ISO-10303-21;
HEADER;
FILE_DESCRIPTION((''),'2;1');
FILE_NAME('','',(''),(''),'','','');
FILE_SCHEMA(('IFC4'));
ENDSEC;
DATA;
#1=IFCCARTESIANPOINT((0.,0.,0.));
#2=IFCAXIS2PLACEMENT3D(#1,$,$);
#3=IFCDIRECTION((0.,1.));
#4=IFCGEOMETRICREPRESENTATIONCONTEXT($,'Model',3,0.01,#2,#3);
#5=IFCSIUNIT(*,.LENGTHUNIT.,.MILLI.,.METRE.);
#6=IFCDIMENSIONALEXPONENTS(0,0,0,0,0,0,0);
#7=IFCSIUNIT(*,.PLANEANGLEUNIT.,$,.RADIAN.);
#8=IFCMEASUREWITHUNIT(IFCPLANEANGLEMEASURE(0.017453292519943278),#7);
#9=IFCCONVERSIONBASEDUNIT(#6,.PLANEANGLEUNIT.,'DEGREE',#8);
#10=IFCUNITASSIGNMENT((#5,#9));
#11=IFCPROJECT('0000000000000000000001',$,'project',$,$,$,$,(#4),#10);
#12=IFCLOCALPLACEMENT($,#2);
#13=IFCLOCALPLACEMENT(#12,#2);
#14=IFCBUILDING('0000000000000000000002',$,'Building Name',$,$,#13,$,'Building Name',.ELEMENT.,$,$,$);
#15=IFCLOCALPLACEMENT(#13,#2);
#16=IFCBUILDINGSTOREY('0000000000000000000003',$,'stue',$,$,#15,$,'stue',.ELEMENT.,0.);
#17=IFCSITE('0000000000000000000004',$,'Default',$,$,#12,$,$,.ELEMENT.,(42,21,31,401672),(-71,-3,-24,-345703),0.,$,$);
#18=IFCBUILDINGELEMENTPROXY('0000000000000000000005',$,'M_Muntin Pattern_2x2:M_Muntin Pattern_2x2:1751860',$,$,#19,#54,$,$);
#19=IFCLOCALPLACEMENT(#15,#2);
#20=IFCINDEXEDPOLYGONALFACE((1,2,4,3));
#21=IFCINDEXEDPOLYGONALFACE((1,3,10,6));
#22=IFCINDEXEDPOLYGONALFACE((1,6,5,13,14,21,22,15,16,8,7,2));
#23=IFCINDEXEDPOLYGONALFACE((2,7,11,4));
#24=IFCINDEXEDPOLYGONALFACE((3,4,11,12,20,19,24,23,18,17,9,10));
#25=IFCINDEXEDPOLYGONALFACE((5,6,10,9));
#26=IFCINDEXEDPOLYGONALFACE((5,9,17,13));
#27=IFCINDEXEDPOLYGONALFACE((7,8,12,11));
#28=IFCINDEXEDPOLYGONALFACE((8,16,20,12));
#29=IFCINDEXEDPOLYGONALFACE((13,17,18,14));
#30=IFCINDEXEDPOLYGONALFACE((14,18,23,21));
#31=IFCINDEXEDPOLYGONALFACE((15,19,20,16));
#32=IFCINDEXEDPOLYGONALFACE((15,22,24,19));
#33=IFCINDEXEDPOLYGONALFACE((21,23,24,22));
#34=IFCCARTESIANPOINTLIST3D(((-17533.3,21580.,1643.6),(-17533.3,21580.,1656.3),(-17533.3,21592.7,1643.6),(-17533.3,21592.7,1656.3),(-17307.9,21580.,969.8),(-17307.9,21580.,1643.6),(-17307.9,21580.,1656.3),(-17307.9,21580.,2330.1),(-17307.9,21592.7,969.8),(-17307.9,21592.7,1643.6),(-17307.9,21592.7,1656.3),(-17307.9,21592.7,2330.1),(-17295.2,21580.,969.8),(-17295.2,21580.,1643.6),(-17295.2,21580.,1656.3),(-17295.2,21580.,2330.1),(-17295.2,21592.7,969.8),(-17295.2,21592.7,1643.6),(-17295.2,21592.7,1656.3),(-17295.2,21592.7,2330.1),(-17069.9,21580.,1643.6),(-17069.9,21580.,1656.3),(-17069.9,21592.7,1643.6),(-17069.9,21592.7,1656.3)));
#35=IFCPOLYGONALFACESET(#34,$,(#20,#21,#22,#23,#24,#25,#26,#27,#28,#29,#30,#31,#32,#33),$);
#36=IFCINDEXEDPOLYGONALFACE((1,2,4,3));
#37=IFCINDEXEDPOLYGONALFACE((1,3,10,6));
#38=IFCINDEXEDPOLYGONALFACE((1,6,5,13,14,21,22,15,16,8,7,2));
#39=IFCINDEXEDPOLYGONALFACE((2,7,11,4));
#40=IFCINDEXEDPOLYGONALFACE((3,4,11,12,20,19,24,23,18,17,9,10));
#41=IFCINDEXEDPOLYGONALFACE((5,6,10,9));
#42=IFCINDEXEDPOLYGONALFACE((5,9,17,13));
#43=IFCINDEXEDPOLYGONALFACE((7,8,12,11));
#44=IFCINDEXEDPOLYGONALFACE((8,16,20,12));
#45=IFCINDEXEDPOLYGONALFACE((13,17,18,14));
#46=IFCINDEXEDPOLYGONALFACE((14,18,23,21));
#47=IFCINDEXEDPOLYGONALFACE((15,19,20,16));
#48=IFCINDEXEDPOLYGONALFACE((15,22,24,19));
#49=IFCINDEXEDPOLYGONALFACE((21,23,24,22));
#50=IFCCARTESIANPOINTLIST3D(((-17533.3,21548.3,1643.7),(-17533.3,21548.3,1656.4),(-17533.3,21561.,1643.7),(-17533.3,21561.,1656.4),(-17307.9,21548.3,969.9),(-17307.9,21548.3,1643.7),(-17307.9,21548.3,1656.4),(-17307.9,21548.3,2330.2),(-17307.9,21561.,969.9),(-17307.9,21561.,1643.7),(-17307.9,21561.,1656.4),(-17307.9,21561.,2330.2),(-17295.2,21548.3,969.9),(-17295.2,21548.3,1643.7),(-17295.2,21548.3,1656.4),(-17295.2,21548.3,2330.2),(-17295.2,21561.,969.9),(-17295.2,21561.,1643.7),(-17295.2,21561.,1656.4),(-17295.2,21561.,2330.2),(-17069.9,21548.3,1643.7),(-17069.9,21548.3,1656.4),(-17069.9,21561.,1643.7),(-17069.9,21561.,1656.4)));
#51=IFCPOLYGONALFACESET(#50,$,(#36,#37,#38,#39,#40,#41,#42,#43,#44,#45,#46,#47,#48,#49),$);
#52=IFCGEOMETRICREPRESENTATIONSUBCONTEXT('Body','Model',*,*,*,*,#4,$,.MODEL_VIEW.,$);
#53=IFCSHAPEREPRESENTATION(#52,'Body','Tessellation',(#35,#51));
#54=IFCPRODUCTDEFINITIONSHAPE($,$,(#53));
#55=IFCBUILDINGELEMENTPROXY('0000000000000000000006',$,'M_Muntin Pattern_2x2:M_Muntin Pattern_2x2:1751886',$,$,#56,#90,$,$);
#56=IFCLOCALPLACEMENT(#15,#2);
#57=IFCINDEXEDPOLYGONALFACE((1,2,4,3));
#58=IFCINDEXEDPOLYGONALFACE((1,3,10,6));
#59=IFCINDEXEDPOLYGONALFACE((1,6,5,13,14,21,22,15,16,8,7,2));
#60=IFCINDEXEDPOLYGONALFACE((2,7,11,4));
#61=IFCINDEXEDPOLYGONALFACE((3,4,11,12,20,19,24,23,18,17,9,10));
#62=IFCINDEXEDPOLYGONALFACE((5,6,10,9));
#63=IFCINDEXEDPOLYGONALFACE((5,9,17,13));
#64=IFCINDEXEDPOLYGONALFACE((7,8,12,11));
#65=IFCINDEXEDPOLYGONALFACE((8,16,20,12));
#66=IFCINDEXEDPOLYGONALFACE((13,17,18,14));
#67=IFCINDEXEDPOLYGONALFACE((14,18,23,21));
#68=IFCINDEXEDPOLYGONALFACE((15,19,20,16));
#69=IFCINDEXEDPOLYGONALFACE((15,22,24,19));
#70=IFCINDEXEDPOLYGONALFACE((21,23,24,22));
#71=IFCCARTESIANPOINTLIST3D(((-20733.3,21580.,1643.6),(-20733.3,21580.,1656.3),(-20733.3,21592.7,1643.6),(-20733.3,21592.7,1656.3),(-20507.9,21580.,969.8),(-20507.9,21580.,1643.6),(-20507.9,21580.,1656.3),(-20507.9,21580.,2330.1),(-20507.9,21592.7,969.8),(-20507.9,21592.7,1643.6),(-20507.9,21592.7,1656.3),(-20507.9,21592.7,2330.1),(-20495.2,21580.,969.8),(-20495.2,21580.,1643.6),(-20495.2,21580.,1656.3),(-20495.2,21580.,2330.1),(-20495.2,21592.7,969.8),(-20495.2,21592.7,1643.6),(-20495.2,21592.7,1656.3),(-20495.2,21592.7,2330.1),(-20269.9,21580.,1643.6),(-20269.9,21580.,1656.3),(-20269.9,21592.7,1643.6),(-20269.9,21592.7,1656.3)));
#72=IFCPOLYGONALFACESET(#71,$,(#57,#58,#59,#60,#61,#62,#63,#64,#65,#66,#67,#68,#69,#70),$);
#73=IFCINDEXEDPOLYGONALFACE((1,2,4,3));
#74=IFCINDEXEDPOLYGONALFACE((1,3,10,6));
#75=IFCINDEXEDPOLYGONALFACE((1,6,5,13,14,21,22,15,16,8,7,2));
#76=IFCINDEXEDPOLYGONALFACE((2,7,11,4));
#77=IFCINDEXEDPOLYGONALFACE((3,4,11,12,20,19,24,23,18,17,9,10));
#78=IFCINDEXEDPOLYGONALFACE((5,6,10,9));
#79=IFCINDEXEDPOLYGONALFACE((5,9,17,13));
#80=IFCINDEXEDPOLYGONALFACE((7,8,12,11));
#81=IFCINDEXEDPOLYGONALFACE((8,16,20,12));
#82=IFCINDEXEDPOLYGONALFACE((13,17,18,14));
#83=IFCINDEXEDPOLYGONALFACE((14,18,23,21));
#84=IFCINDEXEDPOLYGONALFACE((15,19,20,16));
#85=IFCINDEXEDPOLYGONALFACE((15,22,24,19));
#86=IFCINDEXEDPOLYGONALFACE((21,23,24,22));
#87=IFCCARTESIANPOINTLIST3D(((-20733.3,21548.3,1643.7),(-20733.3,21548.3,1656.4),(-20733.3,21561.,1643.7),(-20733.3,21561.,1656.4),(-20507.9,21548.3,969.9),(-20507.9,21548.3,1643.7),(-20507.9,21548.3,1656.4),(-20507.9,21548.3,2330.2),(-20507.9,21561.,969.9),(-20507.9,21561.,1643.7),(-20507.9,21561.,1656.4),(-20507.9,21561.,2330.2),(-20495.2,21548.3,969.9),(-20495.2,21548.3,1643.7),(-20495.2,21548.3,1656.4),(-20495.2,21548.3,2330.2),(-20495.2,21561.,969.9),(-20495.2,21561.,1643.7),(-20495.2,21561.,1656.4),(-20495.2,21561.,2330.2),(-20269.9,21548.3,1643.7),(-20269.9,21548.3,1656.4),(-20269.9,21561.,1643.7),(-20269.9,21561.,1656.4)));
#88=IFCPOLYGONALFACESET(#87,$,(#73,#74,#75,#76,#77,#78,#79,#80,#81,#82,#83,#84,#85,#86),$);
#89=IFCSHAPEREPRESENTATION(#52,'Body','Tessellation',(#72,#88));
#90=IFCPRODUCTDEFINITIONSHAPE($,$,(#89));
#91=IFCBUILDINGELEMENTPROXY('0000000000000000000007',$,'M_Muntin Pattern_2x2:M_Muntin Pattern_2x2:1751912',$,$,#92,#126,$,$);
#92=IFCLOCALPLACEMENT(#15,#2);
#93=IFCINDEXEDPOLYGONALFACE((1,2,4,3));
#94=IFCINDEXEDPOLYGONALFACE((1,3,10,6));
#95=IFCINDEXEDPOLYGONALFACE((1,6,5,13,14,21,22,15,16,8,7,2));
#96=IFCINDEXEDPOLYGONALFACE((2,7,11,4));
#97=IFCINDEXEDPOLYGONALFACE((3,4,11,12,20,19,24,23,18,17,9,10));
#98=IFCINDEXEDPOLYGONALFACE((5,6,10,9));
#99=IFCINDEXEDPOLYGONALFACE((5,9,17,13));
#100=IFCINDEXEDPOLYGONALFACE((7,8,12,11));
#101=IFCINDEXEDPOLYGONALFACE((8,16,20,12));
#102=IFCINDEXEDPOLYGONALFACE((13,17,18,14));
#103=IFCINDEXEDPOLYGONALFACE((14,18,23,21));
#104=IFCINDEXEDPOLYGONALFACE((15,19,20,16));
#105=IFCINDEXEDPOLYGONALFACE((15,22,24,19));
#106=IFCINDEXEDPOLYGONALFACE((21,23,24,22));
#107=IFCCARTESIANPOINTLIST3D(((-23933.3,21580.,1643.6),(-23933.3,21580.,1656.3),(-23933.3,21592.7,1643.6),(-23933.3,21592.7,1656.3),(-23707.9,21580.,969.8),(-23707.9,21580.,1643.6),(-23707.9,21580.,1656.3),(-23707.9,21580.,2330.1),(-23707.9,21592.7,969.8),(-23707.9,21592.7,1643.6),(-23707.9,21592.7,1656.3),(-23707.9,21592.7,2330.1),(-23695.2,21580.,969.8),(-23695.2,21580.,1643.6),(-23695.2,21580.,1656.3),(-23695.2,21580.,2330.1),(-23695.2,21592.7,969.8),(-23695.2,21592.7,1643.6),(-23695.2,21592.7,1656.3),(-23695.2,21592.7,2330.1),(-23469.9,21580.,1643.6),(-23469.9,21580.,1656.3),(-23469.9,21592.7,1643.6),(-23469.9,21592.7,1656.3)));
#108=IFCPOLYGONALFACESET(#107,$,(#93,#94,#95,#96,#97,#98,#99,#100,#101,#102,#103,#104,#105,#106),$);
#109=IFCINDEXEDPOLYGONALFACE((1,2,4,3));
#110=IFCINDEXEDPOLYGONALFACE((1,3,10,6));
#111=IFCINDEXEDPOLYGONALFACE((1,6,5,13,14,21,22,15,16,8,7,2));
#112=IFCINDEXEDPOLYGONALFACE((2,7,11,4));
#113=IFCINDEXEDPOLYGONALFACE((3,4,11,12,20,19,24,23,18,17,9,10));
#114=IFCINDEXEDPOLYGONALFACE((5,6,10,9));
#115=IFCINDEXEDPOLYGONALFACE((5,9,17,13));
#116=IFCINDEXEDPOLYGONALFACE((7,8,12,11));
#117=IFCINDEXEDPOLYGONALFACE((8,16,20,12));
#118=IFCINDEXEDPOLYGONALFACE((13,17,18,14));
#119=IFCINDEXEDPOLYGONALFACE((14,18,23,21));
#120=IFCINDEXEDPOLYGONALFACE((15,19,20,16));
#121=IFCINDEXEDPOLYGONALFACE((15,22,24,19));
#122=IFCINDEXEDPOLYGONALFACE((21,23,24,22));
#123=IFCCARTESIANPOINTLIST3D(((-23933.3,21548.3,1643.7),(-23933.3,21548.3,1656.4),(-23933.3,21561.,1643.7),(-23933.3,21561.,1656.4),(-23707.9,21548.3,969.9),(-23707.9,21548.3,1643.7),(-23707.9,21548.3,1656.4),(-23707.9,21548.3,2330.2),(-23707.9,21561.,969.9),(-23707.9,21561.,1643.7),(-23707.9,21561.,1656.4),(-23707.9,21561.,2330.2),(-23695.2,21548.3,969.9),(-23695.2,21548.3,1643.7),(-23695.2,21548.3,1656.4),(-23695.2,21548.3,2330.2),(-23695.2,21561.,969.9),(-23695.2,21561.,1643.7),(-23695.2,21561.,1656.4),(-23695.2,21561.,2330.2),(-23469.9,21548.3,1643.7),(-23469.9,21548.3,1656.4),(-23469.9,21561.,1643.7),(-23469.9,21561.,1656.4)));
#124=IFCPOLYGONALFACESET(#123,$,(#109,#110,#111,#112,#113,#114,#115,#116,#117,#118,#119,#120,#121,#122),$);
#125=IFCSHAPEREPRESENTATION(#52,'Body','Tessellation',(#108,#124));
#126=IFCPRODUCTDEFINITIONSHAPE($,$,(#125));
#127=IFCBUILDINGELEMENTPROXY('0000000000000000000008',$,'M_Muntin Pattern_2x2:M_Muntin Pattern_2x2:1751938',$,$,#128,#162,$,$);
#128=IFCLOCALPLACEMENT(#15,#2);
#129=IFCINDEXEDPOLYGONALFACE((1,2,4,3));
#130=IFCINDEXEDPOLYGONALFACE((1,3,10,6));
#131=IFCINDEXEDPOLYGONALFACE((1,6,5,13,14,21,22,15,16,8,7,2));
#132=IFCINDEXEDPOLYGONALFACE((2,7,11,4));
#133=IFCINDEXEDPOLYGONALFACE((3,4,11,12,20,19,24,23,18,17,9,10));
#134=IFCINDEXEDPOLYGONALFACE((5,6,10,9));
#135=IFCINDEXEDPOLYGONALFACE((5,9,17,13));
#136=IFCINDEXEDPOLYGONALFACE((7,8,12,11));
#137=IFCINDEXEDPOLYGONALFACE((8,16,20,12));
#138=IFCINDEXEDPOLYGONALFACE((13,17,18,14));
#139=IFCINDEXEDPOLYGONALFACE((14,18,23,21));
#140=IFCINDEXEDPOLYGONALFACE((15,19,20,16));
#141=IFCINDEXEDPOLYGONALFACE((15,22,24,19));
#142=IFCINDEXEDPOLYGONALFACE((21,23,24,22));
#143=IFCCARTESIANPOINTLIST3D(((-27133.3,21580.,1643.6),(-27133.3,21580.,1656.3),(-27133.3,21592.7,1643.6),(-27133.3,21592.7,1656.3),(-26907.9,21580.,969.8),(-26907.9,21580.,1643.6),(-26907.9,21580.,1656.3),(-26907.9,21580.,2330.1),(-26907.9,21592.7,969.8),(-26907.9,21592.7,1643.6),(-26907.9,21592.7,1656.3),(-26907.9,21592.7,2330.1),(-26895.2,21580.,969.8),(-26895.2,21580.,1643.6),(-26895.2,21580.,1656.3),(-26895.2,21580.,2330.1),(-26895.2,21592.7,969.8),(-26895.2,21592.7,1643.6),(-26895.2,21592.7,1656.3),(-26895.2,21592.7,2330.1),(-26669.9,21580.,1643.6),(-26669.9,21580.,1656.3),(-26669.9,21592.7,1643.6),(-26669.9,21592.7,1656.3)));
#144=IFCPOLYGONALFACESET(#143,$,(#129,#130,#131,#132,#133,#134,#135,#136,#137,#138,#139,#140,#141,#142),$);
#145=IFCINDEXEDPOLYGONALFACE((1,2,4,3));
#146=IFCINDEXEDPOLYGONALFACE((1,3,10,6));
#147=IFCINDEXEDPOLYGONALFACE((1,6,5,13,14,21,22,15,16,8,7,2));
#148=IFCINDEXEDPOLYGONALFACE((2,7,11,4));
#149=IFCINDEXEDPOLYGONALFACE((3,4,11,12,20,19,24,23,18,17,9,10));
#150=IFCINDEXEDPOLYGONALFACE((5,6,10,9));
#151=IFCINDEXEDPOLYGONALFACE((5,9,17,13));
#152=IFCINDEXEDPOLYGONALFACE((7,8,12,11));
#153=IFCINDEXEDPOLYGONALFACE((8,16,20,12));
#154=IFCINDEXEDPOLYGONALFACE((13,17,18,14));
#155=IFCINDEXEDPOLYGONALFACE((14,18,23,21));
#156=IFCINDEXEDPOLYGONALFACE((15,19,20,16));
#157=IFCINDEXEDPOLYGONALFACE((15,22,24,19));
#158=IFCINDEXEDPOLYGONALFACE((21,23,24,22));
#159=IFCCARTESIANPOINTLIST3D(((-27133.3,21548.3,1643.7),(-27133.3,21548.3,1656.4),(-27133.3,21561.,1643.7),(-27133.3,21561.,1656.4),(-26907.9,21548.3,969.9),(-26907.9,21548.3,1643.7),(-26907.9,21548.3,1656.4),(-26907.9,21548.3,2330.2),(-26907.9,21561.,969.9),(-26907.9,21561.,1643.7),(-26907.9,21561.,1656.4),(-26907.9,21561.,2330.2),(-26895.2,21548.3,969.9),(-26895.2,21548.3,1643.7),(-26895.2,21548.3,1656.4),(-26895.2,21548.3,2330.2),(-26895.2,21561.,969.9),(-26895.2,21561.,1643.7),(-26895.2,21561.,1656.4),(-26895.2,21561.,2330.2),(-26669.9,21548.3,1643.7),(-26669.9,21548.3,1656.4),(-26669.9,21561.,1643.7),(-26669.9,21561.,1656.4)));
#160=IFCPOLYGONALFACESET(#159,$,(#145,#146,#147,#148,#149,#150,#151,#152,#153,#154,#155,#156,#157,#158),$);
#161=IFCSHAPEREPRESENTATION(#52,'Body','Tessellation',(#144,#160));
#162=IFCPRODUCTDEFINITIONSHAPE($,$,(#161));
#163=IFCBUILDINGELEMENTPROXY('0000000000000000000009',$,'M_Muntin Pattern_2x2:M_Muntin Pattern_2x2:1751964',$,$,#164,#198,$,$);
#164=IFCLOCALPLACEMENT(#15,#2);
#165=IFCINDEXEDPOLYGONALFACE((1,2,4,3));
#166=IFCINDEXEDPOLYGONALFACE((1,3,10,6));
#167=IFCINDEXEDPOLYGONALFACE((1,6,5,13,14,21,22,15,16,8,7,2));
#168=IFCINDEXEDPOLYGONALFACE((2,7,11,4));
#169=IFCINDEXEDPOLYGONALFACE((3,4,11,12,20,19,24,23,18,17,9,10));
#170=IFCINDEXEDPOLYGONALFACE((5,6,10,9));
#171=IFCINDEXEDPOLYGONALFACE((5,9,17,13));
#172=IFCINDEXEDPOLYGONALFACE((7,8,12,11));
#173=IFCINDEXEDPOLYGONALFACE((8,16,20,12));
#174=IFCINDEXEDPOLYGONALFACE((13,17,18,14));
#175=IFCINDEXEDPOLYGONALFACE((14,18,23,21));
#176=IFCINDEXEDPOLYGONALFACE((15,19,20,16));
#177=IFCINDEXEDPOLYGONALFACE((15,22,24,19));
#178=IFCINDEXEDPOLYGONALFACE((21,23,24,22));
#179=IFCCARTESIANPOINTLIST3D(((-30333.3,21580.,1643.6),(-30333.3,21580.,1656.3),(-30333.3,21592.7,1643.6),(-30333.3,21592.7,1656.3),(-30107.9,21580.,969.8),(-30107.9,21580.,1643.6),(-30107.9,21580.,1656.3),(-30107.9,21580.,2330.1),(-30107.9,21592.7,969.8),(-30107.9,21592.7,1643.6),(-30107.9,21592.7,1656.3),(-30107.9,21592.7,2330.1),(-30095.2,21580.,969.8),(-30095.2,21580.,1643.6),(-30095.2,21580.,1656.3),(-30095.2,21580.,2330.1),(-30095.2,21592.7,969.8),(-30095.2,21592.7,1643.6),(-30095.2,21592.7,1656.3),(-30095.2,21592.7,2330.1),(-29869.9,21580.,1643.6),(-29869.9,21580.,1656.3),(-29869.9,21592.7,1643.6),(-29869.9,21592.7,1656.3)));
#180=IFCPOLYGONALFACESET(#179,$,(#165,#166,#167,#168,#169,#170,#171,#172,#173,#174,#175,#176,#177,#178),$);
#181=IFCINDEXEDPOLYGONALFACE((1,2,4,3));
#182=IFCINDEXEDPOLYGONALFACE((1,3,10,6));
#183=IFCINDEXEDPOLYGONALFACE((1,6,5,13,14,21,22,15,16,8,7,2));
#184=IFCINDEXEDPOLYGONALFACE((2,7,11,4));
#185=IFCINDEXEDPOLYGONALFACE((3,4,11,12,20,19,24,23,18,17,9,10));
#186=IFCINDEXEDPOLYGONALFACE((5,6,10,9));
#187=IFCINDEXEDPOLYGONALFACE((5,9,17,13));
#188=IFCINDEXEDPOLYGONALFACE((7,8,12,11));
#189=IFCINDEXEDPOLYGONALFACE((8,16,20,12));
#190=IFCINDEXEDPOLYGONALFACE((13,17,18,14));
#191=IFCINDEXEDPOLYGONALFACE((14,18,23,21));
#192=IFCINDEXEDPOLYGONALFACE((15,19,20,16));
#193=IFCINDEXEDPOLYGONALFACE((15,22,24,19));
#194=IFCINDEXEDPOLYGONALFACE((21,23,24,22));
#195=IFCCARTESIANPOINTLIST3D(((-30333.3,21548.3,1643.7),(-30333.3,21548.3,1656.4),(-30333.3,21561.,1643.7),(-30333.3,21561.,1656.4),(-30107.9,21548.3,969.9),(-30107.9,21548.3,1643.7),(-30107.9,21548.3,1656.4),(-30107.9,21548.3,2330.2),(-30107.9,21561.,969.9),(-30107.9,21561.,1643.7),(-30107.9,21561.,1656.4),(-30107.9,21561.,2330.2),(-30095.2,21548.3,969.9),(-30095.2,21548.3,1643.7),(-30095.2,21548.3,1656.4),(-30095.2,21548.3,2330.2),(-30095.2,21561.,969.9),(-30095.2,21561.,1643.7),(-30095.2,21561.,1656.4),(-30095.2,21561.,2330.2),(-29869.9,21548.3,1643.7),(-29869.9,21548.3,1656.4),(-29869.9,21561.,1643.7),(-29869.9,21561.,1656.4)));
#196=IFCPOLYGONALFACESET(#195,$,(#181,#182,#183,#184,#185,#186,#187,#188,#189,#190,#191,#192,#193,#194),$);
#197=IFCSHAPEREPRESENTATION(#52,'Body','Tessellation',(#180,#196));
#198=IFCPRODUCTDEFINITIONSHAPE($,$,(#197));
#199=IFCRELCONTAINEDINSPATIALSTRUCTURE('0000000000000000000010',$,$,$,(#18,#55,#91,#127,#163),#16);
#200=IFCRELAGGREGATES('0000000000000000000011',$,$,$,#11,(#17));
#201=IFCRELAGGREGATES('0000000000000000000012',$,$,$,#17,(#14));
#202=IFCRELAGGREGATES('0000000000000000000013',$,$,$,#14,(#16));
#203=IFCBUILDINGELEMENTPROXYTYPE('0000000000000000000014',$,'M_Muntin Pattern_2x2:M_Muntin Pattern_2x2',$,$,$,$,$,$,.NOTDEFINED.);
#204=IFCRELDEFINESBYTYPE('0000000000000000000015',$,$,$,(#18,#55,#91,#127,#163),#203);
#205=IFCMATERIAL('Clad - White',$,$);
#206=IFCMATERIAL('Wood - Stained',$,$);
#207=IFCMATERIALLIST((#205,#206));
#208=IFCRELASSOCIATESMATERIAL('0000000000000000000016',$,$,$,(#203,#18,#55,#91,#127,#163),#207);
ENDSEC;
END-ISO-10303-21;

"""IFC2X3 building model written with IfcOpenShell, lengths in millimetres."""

from ifc_helpers import new_model, entity, si_unit, converted_unit, direction, frame, origin, place, context, subcontext, project, spatial, polyline, outline, extrude, source, transform, mapped, material, material_list, type_object, type_shapes, element, save


model = new_model("IFC2X3")

# Units and contexts
model_context = context("Model", 3, precision=0.01, world=origin(), true_north=direction((0.0, 1.0)))
body_context = subcontext(model_context, "Body", "Model", "MODEL_VIEW")
ifc_project = project(units=[si_unit("LENGTHUNIT", "METRE", prefix="MILLI"), converted_unit("PLANEANGLEUNIT", "DEGREE", entity("IfcPlaneAngleMeasure", 0.017453292519943278), si_unit("PLANEANGLEUNIT", "RADIAN"), dimensions=[0, 0, 0, 0, 0, 0, 0])], contexts=[model_context])

# Site, building, storey
site_placement = place(None, origin())
site = spatial("IfcSite", under=ifc_project, at=site_placement, Name="Default", CompositionType="ELEMENT", RefLatitude=(42, 21, 31, 401672), RefLongitude=(-71, -3, -24, -345703), RefElevation=0.0)
building_placement = place(site_placement, origin())
building = spatial("IfcBuilding", under=site, at=building_placement, Name="Building Name", LongName="Building Name", CompositionType="ELEMENT")
storey_placement = place(building_placement, origin())
storey = spatial("IfcBuildingStorey", under=building, at=storey_placement, Name="stue", LongName="stue", CompositionType="ELEMENT", Elevation=0.0)

# Building element proxies
ifc_material_1 = material(Name="Clad - White")
ifc_material_2 = material(Name="Wood - Stained")
ifc_material_list = material_list([ifc_material_1, ifc_material_2])
building_element_proxy_type_1 = type_object("IfcBuildingElementProxyType", Name="M_Muntin Pattern_2x2:M_Muntin Pattern_2x2", PredefinedType="NOTDEFINED", material=ifc_material_list)
shared_shape_1 = source(origin(), body_context, "Body", "SweptSolid", [
    extrude(outline(polyline([(6.4, -6.4), (680.1, -6.4), (680.1, 6.3), (6.4, 6.3), (6.4, 231.7), (-6.3, 231.7), (-6.3, 6.3), (-680.2, 6.3), (-680.2, -6.4), (-6.3, -6.4), (-6.3, -231.7), (6.4, -231.7), (6.4, -6.4)])), frame((0.0, -22.2, 680.1), z_axis=(0.0, 1.0, 0.0), x_axis=(0.0, 0.0, 1.0)), (0.0, 0.0, 1.0), 12.7),
    extrude(outline(polyline([(6.4, -6.4), (680.2, -6.4), (680.2, 6.3), (6.4, 6.3), (6.4, 231.7), (-6.3, 231.7), (-6.3, 6.3), (-680.2, 6.3), (-680.2, -6.4), (-6.3, -6.4), (-6.3, -231.7), (6.4, -231.7), (6.4, -6.4)])), frame((0.0, 9.5, 680.2), z_axis=(0.0, 1.0, 0.0), x_axis=(0.0, 0.0, 1.0)), (0.0, 0.0, 1.0), 12.7),
])
type_shapes(building_element_proxy_type_1, [shared_shape_1])
for number, where, z_axis, x_axis, name in (
    (1, (-17301.6, 21570.5, 969.9), (0.0, 0.0, 1.0), (-1.0, 0.0, 0.0), "M_Muntin Pattern_2x2:M_Muntin Pattern_2x2:1751860"),
    (2, (-20501.6, 21570.5, 969.9), (0.0, 0.0, 1.0), (-1.0, 0.0, 0.0), "M_Muntin Pattern_2x2:M_Muntin Pattern_2x2:1751886"),
    (3, (-23701.6, 21570.5, 969.9), (0.0, 0.0, 1.0), (-1.0, 0.0, 0.0), "M_Muntin Pattern_2x2:M_Muntin Pattern_2x2:1751912"),
    (4, (-26901.6, 21570.5, 969.9), (0.0, 0.0, 1.0), (-1.0, 0.0, 0.0), "M_Muntin Pattern_2x2:M_Muntin Pattern_2x2:1751938"),
    (5, (-30101.6, 21570.5, 969.9), (0.0, 0.0, 1.0), (-1.0, 0.0, 0.0), "M_Muntin Pattern_2x2:M_Muntin Pattern_2x2:1751964"),
):
    element("IfcBuildingElementProxy", number, at=place(storey_placement, frame(where, z_axis=z_axis, x_axis=x_axis)), inside=storey, type_object=building_element_proxy_type_1, material=ifc_material_list, Name=name, context=body_context, shape_type="MappedRepresentation", body=[
        mapped(shared_shape_1, transform((0.0, 0.0, 0.0), scale=1.0)),
    ])

save(model, "model.ifc")
